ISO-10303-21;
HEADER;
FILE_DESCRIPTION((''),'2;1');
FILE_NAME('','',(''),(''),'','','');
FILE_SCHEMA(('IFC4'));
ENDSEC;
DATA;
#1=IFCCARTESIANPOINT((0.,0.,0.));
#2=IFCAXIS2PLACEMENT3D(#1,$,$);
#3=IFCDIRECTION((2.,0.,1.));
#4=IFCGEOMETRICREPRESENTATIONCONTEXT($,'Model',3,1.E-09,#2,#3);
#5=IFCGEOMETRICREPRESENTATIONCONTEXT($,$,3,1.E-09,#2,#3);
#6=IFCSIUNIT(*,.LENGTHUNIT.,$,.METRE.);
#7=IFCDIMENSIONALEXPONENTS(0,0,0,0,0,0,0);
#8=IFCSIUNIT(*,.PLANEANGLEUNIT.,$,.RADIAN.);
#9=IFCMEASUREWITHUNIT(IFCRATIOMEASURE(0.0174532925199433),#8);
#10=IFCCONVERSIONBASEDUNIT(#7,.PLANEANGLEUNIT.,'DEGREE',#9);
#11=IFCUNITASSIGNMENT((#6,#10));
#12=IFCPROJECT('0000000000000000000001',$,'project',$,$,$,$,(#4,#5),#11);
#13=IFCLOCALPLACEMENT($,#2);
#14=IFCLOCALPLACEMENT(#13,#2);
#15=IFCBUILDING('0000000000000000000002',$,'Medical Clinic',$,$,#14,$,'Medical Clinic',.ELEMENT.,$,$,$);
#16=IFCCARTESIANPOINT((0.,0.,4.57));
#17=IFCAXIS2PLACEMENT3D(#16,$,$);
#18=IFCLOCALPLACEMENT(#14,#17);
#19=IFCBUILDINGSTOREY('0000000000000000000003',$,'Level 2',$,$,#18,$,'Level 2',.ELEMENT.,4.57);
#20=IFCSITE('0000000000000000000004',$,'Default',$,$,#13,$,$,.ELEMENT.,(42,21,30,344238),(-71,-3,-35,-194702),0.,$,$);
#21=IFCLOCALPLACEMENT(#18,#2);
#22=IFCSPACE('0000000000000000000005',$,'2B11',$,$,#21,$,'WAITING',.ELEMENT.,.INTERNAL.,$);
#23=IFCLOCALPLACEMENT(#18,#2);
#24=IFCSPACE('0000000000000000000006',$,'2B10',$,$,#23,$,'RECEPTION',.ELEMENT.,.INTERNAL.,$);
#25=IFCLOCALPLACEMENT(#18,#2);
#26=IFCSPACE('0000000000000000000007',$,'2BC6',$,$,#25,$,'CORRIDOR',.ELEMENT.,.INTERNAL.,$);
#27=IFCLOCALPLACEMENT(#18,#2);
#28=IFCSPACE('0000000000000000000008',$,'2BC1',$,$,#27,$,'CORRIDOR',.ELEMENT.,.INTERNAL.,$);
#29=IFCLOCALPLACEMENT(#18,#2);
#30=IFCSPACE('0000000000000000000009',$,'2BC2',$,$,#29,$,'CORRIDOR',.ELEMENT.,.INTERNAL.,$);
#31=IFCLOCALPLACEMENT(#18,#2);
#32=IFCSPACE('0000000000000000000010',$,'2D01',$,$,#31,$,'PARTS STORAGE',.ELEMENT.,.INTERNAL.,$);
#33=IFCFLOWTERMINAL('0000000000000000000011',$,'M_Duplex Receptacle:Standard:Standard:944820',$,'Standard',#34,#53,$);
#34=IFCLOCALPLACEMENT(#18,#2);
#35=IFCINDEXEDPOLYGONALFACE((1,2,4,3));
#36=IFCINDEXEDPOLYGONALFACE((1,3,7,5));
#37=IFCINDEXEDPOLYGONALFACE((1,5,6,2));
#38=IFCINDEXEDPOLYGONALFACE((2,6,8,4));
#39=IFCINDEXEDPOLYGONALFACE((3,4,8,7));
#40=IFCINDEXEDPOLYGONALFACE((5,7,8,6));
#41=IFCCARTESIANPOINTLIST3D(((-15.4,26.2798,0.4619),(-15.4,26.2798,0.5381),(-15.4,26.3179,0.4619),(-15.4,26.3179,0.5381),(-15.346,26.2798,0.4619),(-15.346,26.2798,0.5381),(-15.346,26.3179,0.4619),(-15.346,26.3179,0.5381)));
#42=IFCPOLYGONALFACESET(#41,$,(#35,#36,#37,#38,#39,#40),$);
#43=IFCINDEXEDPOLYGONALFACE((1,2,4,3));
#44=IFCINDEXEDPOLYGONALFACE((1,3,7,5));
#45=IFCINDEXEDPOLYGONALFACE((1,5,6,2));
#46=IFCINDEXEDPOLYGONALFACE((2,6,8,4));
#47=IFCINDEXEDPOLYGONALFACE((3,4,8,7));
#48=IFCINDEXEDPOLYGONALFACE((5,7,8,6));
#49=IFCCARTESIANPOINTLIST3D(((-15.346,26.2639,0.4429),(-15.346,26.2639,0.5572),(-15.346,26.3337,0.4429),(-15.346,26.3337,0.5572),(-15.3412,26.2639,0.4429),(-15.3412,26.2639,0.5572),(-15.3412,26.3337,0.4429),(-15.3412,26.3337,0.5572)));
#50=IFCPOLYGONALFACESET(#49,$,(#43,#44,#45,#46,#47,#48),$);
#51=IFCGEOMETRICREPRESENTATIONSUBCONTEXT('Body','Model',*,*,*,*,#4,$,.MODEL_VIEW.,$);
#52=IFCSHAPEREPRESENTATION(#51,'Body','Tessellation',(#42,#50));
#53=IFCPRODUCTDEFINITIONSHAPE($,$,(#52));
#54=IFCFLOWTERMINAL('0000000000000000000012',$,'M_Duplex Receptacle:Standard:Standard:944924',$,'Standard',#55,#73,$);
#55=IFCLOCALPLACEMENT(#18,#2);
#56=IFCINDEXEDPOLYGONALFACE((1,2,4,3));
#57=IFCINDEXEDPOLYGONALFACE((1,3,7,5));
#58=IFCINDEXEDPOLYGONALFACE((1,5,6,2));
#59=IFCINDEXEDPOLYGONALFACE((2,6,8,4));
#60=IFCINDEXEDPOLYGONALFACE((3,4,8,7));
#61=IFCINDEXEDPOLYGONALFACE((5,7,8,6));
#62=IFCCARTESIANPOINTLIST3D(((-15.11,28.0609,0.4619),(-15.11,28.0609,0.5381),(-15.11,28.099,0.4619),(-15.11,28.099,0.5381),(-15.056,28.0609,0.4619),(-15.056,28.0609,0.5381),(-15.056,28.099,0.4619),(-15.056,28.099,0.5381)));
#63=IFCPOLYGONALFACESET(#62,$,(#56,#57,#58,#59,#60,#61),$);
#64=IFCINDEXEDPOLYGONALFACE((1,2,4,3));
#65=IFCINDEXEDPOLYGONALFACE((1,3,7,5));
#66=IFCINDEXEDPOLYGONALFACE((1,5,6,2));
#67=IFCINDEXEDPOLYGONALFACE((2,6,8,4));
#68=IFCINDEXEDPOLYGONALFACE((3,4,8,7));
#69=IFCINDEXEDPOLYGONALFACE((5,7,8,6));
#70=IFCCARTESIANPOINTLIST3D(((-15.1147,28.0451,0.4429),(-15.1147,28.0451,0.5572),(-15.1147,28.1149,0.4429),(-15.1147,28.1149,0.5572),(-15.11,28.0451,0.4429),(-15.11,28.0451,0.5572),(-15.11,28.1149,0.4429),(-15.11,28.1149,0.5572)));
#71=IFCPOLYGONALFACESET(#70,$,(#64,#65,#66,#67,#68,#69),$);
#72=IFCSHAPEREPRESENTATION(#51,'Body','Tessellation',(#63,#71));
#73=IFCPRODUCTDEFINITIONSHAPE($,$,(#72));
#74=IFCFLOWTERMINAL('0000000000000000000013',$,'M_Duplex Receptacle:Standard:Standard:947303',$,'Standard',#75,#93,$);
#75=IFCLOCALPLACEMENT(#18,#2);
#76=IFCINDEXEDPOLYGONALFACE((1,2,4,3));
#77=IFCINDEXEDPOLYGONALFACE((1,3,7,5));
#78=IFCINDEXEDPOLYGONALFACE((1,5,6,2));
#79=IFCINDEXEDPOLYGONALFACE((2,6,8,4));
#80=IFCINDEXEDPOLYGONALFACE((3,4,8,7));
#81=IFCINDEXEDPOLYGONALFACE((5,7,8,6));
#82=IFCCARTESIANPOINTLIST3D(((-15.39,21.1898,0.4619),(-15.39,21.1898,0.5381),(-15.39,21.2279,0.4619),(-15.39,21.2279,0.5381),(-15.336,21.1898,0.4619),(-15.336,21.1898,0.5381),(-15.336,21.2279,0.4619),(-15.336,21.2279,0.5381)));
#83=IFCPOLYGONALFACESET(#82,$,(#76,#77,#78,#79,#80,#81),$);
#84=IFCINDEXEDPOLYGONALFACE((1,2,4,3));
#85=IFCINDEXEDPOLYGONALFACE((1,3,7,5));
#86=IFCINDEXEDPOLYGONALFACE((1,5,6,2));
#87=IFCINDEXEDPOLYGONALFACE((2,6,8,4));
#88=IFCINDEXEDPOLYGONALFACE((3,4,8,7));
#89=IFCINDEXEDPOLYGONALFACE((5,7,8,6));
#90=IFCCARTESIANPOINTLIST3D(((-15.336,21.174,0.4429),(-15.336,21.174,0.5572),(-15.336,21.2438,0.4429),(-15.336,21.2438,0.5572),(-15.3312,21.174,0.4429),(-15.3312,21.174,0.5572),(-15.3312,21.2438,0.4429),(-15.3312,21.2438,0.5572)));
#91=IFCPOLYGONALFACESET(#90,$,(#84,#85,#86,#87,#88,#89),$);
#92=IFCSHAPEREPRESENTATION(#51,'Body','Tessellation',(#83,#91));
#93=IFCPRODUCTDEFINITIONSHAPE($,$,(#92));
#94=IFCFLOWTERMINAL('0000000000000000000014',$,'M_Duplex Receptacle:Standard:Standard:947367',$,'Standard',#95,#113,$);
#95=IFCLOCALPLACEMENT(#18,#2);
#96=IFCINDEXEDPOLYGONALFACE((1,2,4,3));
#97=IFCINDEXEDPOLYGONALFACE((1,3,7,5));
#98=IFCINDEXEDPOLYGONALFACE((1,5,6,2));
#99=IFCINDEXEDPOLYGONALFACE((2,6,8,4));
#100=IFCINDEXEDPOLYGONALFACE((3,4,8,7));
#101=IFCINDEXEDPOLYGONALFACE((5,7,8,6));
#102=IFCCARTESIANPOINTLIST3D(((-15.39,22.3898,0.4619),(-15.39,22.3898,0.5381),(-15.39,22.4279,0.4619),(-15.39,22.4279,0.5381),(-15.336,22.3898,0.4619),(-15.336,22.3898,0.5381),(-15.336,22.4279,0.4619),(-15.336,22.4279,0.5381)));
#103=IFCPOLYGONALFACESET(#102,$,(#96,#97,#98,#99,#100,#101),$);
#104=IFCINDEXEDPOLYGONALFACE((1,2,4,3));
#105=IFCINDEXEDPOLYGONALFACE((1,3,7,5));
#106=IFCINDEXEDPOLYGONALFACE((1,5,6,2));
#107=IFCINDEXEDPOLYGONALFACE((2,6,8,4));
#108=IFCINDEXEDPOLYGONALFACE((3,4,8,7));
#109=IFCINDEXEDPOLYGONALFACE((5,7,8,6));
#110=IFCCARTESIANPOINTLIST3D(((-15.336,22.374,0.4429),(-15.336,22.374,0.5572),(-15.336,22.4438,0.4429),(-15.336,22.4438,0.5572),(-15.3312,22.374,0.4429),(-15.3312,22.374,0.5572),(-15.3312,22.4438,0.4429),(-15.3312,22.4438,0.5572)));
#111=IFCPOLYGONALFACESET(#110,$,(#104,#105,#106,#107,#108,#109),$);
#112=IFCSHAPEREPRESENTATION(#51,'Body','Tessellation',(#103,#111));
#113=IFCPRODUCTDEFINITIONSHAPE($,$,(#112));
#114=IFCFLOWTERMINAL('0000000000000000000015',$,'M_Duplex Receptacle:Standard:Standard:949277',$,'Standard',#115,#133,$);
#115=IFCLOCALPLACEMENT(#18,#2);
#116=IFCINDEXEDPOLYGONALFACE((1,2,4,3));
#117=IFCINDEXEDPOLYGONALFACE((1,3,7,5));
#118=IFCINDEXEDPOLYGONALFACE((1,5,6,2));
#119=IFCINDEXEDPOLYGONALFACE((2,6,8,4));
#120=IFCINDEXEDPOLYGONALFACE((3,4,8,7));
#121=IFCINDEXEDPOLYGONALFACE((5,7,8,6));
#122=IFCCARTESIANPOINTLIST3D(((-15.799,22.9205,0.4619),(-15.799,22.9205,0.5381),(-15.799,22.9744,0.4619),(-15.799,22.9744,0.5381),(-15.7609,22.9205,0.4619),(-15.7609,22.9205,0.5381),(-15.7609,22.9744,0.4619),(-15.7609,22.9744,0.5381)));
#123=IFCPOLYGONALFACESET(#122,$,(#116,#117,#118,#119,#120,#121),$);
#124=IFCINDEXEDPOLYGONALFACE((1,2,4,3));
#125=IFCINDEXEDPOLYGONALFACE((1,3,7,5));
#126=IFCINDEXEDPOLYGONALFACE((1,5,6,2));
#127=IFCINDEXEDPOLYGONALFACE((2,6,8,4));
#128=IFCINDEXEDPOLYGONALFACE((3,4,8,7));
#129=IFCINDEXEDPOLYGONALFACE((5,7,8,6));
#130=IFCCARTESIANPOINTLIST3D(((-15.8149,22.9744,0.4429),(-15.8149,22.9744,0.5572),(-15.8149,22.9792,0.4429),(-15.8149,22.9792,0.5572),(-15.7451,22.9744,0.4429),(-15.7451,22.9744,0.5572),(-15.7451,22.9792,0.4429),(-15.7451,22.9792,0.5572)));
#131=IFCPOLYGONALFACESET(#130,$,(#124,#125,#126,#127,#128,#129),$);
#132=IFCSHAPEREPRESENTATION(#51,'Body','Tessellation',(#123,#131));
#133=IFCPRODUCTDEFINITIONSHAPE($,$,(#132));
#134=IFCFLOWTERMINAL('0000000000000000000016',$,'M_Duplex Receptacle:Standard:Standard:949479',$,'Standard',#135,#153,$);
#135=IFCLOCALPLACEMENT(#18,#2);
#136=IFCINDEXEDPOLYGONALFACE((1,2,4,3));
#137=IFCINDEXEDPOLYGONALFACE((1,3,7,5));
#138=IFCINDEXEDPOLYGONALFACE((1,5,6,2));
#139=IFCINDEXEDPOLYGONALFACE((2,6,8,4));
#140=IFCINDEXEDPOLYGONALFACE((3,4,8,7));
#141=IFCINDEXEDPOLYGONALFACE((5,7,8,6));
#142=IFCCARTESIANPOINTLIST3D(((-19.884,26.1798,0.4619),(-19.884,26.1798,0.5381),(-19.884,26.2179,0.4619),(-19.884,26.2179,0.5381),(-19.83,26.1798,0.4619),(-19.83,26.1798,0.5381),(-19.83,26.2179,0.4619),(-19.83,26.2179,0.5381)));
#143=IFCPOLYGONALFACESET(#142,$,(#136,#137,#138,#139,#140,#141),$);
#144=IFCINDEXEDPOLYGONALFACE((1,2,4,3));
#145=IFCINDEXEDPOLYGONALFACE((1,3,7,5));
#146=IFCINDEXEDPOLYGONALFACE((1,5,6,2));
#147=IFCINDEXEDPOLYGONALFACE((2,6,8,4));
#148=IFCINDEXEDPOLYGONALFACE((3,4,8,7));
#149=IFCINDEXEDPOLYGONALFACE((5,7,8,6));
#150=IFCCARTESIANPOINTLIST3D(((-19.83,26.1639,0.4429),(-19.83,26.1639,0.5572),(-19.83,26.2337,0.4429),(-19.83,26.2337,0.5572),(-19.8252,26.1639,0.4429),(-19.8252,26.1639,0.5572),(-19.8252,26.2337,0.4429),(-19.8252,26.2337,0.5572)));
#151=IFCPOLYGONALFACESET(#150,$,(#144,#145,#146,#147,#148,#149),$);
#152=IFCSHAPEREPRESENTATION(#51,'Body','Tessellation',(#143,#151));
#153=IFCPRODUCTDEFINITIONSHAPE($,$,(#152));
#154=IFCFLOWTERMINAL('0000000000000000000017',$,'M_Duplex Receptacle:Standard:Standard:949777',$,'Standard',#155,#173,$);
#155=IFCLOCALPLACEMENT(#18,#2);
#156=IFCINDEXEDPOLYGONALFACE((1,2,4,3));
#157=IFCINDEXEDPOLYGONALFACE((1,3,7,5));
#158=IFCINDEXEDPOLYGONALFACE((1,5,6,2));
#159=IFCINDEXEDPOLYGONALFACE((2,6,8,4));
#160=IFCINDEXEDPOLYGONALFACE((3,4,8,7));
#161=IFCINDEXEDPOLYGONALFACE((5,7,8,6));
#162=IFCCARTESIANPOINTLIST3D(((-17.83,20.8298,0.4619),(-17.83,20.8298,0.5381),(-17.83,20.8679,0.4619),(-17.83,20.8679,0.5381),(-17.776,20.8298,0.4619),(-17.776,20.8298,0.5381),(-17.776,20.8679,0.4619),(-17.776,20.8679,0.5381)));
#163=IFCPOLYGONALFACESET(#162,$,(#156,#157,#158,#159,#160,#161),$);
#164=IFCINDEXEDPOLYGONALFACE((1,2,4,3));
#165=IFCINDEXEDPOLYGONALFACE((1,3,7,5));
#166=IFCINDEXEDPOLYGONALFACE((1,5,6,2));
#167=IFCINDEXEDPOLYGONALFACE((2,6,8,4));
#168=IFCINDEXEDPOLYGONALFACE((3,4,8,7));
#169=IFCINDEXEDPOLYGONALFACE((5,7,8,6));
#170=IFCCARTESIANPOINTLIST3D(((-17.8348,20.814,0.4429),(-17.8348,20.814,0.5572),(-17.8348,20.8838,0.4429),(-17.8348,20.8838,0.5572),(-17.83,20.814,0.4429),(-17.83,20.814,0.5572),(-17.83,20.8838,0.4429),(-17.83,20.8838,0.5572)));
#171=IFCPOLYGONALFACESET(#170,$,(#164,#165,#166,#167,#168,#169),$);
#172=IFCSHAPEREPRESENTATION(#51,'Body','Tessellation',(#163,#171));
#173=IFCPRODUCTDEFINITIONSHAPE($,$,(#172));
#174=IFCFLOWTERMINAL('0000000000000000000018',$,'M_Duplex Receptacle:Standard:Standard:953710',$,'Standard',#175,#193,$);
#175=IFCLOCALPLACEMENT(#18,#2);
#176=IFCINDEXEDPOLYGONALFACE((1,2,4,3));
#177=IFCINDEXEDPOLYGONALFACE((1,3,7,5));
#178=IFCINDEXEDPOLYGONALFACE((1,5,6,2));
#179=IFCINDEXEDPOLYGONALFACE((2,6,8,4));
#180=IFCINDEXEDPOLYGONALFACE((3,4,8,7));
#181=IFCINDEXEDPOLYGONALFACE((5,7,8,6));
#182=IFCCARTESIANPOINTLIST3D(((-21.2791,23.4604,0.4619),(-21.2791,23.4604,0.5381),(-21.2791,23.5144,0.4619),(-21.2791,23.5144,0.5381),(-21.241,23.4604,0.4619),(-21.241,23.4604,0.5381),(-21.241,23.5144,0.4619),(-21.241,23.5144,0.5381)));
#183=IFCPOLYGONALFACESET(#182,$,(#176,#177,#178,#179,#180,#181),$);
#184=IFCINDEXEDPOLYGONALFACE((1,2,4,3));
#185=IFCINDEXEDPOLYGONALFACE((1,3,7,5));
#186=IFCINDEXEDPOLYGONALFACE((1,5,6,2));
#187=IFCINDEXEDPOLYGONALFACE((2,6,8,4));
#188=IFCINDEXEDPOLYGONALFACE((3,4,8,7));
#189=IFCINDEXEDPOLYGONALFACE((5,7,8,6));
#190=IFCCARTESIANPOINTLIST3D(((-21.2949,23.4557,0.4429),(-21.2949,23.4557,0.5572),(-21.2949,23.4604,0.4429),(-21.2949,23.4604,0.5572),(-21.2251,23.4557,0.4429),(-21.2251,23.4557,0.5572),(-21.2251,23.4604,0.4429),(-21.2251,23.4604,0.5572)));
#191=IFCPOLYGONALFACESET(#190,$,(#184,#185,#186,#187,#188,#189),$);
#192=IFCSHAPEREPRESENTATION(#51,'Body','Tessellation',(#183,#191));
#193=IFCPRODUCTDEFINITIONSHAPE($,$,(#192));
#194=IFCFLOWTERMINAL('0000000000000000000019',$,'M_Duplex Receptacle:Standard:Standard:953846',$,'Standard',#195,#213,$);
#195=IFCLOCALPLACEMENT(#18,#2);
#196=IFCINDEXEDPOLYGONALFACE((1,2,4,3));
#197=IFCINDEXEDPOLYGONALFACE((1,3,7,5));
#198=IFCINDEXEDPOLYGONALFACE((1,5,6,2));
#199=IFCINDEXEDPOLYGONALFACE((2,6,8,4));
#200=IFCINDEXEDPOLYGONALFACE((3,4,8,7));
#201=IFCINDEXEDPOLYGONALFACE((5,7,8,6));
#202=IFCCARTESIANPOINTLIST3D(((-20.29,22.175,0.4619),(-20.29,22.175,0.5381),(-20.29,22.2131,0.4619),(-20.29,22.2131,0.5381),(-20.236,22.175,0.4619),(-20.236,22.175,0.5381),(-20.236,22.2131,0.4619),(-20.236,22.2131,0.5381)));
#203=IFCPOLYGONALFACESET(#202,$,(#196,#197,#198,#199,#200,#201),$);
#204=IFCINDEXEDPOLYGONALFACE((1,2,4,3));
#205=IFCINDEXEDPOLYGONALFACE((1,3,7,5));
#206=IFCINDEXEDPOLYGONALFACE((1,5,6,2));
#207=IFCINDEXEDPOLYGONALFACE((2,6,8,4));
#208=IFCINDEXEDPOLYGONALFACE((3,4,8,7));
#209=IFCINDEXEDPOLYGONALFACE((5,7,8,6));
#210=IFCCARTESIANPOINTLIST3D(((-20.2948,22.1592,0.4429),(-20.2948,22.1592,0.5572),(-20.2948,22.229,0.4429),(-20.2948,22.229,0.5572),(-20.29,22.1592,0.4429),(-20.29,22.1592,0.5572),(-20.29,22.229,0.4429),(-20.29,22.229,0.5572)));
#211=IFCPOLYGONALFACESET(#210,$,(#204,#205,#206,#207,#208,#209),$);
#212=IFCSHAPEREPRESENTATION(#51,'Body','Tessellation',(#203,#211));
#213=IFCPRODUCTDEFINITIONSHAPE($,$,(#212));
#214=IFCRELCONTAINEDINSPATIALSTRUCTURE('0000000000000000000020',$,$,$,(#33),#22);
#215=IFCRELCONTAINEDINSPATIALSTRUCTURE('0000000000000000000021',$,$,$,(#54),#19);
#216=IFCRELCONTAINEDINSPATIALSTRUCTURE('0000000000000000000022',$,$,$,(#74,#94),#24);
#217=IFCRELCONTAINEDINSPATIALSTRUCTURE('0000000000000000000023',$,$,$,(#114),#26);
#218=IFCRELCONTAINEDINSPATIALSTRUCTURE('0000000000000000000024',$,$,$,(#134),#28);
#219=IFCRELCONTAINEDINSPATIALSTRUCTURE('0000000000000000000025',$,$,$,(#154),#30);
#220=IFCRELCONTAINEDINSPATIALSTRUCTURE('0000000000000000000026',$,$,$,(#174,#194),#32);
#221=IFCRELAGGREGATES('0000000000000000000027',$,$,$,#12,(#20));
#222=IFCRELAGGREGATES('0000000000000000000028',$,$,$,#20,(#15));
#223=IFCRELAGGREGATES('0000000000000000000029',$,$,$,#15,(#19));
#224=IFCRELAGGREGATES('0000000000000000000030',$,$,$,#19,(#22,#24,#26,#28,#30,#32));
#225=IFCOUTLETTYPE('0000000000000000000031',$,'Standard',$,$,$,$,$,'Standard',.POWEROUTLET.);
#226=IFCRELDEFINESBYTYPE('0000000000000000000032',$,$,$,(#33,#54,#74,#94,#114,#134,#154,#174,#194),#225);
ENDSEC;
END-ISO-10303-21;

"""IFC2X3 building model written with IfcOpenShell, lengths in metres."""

from ifc_helpers import new_model, entity, si_unit, converted_unit, direction, frame, frame_2d, origin, origin_2d_with_axis, place, context, subcontext, project, spatial, rectangle, extrude, source, transform, mapped, type_object, type_shapes, element, save


model = new_model("IFC2X3")

# Units and contexts
model_context = context("Model", 3, precision=1e-09, world=origin(), true_north=direction((2.0, 0.0, 1.0)))
context_of_model = context(None, 3, precision=1e-09, world=origin(), true_north=direction((2.0, 0.0, 1.0)))
body_context = subcontext(model_context, "Body", "Model", "MODEL_VIEW")
ifc_project = project(units=[si_unit("LENGTHUNIT", "METRE"), converted_unit("PLANEANGLEUNIT", "DEGREE", entity("IfcRatioMeasure", 0.0174532925199433), si_unit("PLANEANGLEUNIT", "RADIAN"), dimensions=[0, 0, 0, 0, 0, 0, 0])], contexts=[model_context, context_of_model])

# Site, building, storey, space
site_placement = place(None, origin())
site = spatial("IfcSite", under=ifc_project, at=site_placement, Name="Default", CompositionType="ELEMENT", RefLatitude=(42, 21, 30, 344238), RefLongitude=(-71, -3, -35, -194702), RefElevation=0.0)
building_placement = place(site_placement, origin())
building = spatial("IfcBuilding", under=site, at=building_placement, Name="Medical Clinic", LongName="Medical Clinic", CompositionType="ELEMENT")
storey_placement = place(building_placement, frame((0.0, 0.0, 4.57)))
storey = spatial("IfcBuildingStorey", under=building, at=storey_placement, Name="Level 2", LongName="Level 2", CompositionType="ELEMENT", Elevation=4.57)
space_1_placement = place(storey_placement, origin())
space_1 = spatial("IfcSpace", under=storey, at=space_1_placement, Name="2B11", LongName="WAITING", CompositionType="ELEMENT", InteriorOrExteriorSpace="INTERNAL")

# Flow terminals
outlet_type = type_object("IfcOutletType", Name="Standard", ElementType="Standard", PredefinedType="POWEROUTLET")
shared_shape_1 = source(origin(), body_context, "Body", "SweptSolid", [
    extrude(rectangle(XDim=0.0381, YDim=0.0762, at=origin_2d_with_axis()), frame((0.0, 0.0, -0.054), z_axis=(0.0, 0.0, 1.0), x_axis=(-1.0, 0.0, 0.0)), (0.0, 0.0, 1.0), 0.054),
    extrude(rectangle(XDim=0.0698, YDim=0.1143, at=frame_2d((0.0, 0.0), x_axis=(1.0, 0.0))), frame((0.0, 0.0, 0.0), z_axis=(0.0, 0.0, 1.0), x_axis=(-1.0, 0.0, 0.0)), (0.0, 0.0, 1.0), 0.0048),
])
type_shapes(outlet_type, [shared_shape_1])
flow_terminal_1_placement = place(space_1_placement, frame((-15.346, 26.2988, 0.5), z_axis=(1.0, 0.0, 0.0), x_axis=(0.0, 1.0, 0.0)))
element("IfcFlowTerminal", 1, at=flow_terminal_1_placement, inside=space_1, type_object=outlet_type, Name="M_Duplex Receptacle:Standard:Standard:944820", ObjectType="Standard", context=body_context, shape_type="MappedRepresentation", body=[
    mapped(shared_shape_1, transform((0.0, 0.0, 0.0), scale=1.0)),
])
flow_terminal_2_placement = place(storey_placement, frame((-15.11, 28.08, 0.5), z_axis=(-1.0, 0.0, 0.0), x_axis=(0.0, -1.0, 0.0)))
element("IfcFlowTerminal", 2, at=flow_terminal_2_placement, inside=storey, type_object=outlet_type, Name="M_Duplex Receptacle:Standard:Standard:944924", ObjectType="Standard", context=body_context, shape_type="MappedRepresentation", body=[
    mapped(shared_shape_1, transform((0.0, 0.0, 0.0), scale=1.0)),
])

# Shared definitions
space_2_placement = place(storey_placement, origin())
space_2 = spatial("IfcSpace", under=storey, at=space_2_placement, Name="2B10", LongName="RECEPTION", CompositionType="ELEMENT", InteriorOrExteriorSpace="INTERNAL")

# Flow terminals
for number, where, z_axis, x_axis, name in (
    (3, (-15.336, 21.2089, 0.5), (1.0, 0.0, 0.0), (0.0, 1.0, 0.0), "M_Duplex Receptacle:Standard:Standard:947303"),
    (4, (-15.336, 22.4089, 0.5), (1.0, 0.0, 0.0), (0.0, 1.0, 0.0), "M_Duplex Receptacle:Standard:Standard:947367"),
):
    element("IfcFlowTerminal", number, at=place(space_2_placement, frame(where, z_axis=z_axis, x_axis=x_axis)), inside=space_2, type_object=outlet_type, Name=name, ObjectType="Standard", context=body_context, shape_type="MappedRepresentation", body=[
        mapped(shared_shape_1, transform((0.0, 0.0, 0.0), scale=1.0)),
    ])

# Shared definitions
space_3_placement = place(storey_placement, origin())
space_3 = spatial("IfcSpace", under=storey, at=space_3_placement, Name="2BC6", LongName="CORRIDOR", CompositionType="ELEMENT", InteriorOrExteriorSpace="INTERNAL")

# Flow terminal
flow_terminal_3_placement = place(space_3_placement, frame((-15.78, 22.9744, 0.5), z_axis=(0.0, 1.0, 0.0), x_axis=(-1.0, 0.0, 0.0)))
element("IfcFlowTerminal", 5, at=flow_terminal_3_placement, inside=space_3, type_object=outlet_type, Name="M_Duplex Receptacle:Standard:Standard:949277", ObjectType="Standard", context=body_context, shape_type="MappedRepresentation", body=[
    mapped(shared_shape_1, transform((0.0, 0.0, 0.0), scale=1.0)),
])

# Shared definitions
space_4_placement = place(storey_placement, origin())
space_4 = spatial("IfcSpace", under=storey, at=space_4_placement, Name="2BC1", LongName="CORRIDOR", CompositionType="ELEMENT", InteriorOrExteriorSpace="INTERNAL")

# Flow terminal
flow_terminal_4_placement = place(space_4_placement, frame((-19.83, 26.1988, 0.5), z_axis=(1.0, 0.0, 0.0), x_axis=(0.0, 1.0, 0.0)))
element("IfcFlowTerminal", 6, at=flow_terminal_4_placement, inside=space_4, type_object=outlet_type, Name="M_Duplex Receptacle:Standard:Standard:949479", ObjectType="Standard", context=body_context, shape_type="MappedRepresentation", body=[
    mapped(shared_shape_1, transform((0.0, 0.0, 0.0), scale=1.0)),
])

# Shared definitions
space_5_placement = place(storey_placement, origin())
space_5 = spatial("IfcSpace", under=storey, at=space_5_placement, Name="2BC2", LongName="CORRIDOR", CompositionType="ELEMENT", InteriorOrExteriorSpace="INTERNAL")

# Flow terminal
flow_terminal_5_placement = place(space_5_placement, frame((-17.83, 20.8489, 0.5), z_axis=(-1.0, 0.0, 0.0), x_axis=(0.0, -1.0, 0.0)))
element("IfcFlowTerminal", 7, at=flow_terminal_5_placement, inside=space_5, type_object=outlet_type, Name="M_Duplex Receptacle:Standard:Standard:949777", ObjectType="Standard", context=body_context, shape_type="MappedRepresentation", body=[
    mapped(shared_shape_1, transform((0.0, 0.0, 0.0), scale=1.0)),
])

# Shared definitions
space_6_placement = place(storey_placement, origin())
space_6 = spatial("IfcSpace", under=storey, at=space_6_placement, Name="2D01", LongName="PARTS STORAGE", CompositionType="ELEMENT", InteriorOrExteriorSpace="INTERNAL")

# Flow terminals
for number, where, z_axis, x_axis, name in (
    (8, (-21.26, 23.4604, 0.5), (0.0, -1.0, 0.0), (1.0, 0.0, 0.0), "M_Duplex Receptacle:Standard:Standard:953710"),
    (9, (-20.29, 22.1941, 0.5), (-1.0, 0.0, 0.0), (0.0, -1.0, 0.0), "M_Duplex Receptacle:Standard:Standard:953846"),
):
    element("IfcFlowTerminal", number, at=place(space_6_placement, frame(where, z_axis=z_axis, x_axis=x_axis)), inside=space_6, type_object=outlet_type, Name=name, ObjectType="Standard", context=body_context, shape_type="MappedRepresentation", body=[
        mapped(shared_shape_1, transform((0.0, 0.0, 0.0), scale=1.0)),
    ])

save(model, "model.ifc")
